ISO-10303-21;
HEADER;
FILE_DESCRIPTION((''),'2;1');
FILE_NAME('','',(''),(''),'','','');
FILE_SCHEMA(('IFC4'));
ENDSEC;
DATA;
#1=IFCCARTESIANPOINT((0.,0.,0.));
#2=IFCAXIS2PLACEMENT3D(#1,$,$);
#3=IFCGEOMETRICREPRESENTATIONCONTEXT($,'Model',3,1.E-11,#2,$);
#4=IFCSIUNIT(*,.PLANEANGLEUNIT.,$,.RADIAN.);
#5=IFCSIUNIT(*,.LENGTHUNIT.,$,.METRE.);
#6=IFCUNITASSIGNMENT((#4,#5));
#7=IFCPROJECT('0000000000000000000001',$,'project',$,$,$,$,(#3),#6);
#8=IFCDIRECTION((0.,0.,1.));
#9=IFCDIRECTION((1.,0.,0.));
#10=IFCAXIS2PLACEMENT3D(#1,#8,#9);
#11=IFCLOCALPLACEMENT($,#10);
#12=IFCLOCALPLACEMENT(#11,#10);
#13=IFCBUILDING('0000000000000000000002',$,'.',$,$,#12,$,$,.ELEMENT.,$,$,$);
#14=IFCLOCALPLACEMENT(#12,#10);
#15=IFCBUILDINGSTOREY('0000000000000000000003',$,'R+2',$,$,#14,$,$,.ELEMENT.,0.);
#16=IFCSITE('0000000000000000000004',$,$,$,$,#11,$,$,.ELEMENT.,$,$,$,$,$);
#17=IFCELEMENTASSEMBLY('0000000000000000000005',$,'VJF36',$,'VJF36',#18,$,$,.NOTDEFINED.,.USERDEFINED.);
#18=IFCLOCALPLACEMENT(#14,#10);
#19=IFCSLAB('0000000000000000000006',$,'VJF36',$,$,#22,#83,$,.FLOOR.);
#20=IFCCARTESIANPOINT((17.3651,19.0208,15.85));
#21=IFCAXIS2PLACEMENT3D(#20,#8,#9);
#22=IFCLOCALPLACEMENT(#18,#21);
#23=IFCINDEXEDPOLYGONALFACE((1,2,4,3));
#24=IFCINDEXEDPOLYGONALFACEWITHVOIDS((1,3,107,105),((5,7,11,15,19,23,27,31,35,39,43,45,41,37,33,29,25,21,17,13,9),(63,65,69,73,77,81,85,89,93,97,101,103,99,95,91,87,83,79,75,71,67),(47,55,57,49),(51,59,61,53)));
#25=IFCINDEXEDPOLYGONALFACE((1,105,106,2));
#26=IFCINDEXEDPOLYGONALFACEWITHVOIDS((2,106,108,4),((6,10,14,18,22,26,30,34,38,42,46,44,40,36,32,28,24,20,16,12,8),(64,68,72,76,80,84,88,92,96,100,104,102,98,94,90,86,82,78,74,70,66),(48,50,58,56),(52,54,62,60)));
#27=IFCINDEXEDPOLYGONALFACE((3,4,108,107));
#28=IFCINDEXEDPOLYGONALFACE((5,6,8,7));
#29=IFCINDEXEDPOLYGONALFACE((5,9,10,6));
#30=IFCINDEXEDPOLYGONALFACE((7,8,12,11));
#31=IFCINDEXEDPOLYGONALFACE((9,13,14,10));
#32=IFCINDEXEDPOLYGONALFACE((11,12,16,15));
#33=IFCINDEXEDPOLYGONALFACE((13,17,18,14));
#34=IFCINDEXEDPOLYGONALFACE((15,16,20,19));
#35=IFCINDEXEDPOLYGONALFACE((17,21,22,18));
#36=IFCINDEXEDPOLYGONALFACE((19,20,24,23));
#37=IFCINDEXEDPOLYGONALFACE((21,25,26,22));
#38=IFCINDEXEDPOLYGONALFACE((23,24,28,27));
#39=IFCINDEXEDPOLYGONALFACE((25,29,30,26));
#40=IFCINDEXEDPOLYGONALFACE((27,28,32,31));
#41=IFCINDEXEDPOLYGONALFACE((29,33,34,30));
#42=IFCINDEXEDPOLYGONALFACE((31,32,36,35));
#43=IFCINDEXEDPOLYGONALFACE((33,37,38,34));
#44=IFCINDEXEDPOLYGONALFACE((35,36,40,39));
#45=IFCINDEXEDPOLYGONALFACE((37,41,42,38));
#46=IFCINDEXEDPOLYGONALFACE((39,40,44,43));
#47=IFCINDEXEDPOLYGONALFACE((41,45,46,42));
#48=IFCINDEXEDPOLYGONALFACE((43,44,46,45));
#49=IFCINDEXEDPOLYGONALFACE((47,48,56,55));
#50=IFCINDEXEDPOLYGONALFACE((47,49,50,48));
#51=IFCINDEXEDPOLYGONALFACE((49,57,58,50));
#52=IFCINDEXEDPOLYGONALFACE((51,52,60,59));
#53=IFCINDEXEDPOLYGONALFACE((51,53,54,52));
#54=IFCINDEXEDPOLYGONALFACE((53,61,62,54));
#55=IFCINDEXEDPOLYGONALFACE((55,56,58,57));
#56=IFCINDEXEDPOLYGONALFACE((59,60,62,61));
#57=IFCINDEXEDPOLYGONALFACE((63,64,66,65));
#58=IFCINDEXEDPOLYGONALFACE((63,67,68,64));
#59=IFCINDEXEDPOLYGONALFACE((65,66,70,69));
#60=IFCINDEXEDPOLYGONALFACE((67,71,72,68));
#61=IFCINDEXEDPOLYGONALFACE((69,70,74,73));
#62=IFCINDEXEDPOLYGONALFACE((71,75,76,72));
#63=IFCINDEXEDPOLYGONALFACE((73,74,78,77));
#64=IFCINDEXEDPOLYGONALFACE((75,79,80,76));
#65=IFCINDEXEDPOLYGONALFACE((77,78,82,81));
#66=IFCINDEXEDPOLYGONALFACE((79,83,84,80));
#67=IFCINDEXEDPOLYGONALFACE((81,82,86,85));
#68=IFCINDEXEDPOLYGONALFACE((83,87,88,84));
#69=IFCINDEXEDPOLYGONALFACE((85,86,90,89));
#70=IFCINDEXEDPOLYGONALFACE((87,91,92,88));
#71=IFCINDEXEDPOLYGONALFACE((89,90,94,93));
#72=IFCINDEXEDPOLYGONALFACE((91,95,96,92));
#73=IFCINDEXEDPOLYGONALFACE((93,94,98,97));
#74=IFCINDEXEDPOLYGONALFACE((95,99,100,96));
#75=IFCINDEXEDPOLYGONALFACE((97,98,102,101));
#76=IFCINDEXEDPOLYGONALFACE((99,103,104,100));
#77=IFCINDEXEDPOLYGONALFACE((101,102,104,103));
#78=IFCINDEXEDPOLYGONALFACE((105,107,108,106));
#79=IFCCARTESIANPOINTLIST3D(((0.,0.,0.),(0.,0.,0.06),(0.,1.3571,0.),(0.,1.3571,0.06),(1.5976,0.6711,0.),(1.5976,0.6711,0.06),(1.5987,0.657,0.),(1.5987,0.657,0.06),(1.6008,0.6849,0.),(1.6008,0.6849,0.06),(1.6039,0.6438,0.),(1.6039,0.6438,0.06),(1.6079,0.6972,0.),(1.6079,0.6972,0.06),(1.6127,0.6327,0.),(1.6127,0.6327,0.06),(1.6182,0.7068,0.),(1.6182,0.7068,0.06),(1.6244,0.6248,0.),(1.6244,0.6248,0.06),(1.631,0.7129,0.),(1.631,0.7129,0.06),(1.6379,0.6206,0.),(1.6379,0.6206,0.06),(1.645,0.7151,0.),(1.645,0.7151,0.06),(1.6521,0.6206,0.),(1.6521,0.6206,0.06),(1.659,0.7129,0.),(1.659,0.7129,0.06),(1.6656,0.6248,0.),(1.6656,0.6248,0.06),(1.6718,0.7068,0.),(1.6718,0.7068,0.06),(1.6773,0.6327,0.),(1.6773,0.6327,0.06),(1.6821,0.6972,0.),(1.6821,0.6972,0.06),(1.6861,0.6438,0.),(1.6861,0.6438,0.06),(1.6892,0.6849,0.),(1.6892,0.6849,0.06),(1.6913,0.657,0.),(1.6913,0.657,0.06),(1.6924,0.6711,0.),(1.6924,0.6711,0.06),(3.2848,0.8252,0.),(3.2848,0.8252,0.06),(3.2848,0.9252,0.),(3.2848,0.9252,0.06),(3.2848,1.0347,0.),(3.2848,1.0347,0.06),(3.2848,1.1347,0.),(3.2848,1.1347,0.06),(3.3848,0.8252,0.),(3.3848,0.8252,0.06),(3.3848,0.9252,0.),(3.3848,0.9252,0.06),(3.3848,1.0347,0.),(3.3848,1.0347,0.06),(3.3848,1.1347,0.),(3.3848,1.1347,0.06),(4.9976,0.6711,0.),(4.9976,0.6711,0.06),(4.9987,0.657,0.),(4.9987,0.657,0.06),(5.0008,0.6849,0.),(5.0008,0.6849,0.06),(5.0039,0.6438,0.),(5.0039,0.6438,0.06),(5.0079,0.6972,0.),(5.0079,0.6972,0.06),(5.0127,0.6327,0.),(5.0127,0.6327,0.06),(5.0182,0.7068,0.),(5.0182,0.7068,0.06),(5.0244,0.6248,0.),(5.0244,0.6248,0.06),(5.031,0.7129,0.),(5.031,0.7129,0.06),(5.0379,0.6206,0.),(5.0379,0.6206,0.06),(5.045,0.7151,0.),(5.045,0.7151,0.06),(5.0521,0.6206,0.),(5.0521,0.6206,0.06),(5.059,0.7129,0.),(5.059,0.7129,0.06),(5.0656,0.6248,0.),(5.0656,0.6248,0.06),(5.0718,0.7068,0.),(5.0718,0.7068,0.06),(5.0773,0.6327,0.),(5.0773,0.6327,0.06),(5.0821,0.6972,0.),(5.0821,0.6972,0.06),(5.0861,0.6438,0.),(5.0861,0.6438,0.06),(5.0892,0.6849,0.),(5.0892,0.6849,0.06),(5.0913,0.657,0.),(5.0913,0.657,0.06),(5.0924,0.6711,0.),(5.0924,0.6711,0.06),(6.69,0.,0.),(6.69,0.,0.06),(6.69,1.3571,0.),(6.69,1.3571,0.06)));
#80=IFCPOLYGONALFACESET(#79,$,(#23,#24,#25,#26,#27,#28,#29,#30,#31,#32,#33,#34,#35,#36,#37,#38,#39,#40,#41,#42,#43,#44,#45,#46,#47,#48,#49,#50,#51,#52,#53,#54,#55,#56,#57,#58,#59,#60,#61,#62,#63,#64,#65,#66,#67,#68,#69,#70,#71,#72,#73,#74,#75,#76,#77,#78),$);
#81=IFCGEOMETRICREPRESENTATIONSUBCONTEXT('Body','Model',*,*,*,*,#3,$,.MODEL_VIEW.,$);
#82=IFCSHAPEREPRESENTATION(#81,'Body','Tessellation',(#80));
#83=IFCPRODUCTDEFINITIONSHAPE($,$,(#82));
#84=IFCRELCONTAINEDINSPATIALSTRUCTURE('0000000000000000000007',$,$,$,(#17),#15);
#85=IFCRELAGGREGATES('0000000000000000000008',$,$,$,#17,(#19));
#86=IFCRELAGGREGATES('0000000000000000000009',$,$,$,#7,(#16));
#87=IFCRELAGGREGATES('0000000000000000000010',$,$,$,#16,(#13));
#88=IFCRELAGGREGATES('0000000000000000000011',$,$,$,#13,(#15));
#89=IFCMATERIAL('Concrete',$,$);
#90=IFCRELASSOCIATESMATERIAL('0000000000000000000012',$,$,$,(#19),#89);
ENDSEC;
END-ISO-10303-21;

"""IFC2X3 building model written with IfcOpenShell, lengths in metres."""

from ifc_helpers import new_model, si_unit, frame, origin, origin_with_axes, origin_2d_with_axis, place, context, subcontext, project, spatial, polyline, circle, outline, extrude, material, element, aggregate, save


model = new_model("IFC2X3")

# Units and contexts
model_context = context("Model", 3, precision=1e-11, world=origin())
body_context = subcontext(model_context, "Body", "Model", "MODEL_VIEW")
ifc_project = project(units=[si_unit("PLANEANGLEUNIT", "RADIAN"), si_unit("LENGTHUNIT", "METRE")], contexts=[model_context])

# Site, building, storey
site_placement = place(None, origin_with_axes())
site = spatial("IfcSite", under=ifc_project, at=site_placement, CompositionType="ELEMENT")
building_placement = place(site_placement, origin_with_axes())
building = spatial("IfcBuilding", under=site, at=building_placement, Name=".", CompositionType="ELEMENT")
storey_placement = place(building_placement, origin_with_axes())
storey = spatial("IfcBuildingStorey", under=building, at=storey_placement, Name="R+2", CompositionType="ELEMENT", Elevation=0.0)

# Element assembly, slab, openings
assembly_1_placement = place(storey_placement, origin_with_axes())
assembly_1 = element("IfcElementAssembly", 1, at=assembly_1_placement, inside=storey, Name="VJF36", ObjectType="VJF36", AssemblyPlace="NOTDEFINED", PredefinedType="USERDEFINED")
ifc_material = material(Name="Concrete")
slab_1_placement = place(assembly_1_placement, frame((17.3651, 19.0208, 15.85), z_axis=(0.0, 0.0, 1.0), x_axis=(1.0, 0.0, 0.0)))
slab_1 = element("IfcSlab", 2, at=slab_1_placement, material=ifc_material, Name="VJF36", PredefinedType="FLOOR", context=body_context, shape_type="SweptSolid", body=[
    extrude(outline(polyline([(0.0, 0.0), (0.0, -6.69), (1.3571, -6.69), (1.3571, 0.0), (0.0, 0.0)])), frame((0.0, 0.0, 0.0), z_axis=(0.0, 0.0, 1.0), x_axis=(0.0, 1.0, 0.0)), (0.0, 0.0, 1.0), 0.06),
])
opening_1_placement = place(slab_1_placement, frame((5.045, 0.6676, 0.0), z_axis=(0.0, 0.0, 1.0), x_axis=(1.0, 0.0, 0.0)))
element("IfcOpeningElement", 3, at=opening_1_placement, cuts=slab_1, ObjectType="Opening", context=body_context, shape_type="SweptSolid", body=[
    extrude(circle(Radius=0.0475, at=origin_2d_with_axis()), frame((0.0, 0.0, 0.0), z_axis=(0.0, 0.0, 1.0), x_axis=(0.0, 1.0, 0.0)), (0.0, 0.0, 1.0), 0.06),
])
opening_2_placement = place(slab_1_placement, frame((1.645, 0.6676, 0.0), z_axis=(0.0, 0.0, 1.0), x_axis=(1.0, 0.0, 0.0)))
element("IfcOpeningElement", 4, at=opening_2_placement, cuts=slab_1, ObjectType="Opening", context=body_context, shape_type="SweptSolid", body=[
    extrude(circle(Radius=0.0475, at=origin_2d_with_axis()), frame((0.0, 0.0, 0.0), z_axis=(0.0, 0.0, 1.0), x_axis=(0.0, 1.0, 0.0)), (0.0, 0.0, 1.0), 0.06),
])
opening_3_placement = place(slab_1_placement, origin_with_axes())
element("IfcOpeningElement", 5, at=opening_3_placement, cuts=slab_1, ObjectType="Opening", context=body_context, shape_type="SweptSolid", body=[
    extrude(outline(polyline([(0.8252, -3.2848), (0.8252, -3.3848), (0.9252, -3.3848), (0.9252, -3.2848), (0.8252, -3.2848)])), frame((0.0, 0.0, 0.0), z_axis=(0.0, 0.0, 1.0), x_axis=(0.0, 1.0, 0.0)), (0.0, 0.0, 1.0), 0.06),
])
opening_4_placement = place(slab_1_placement, origin_with_axes())
element("IfcOpeningElement", 6, at=opening_4_placement, cuts=slab_1, ObjectType="Opening", context=body_context, shape_type="SweptSolid", body=[
    extrude(outline(polyline([(1.0347, -3.2848), (1.0347, -3.3848), (1.1347, -3.3848), (1.1347, -3.2848), (1.0347, -3.2848)])), frame((0.0, 0.0, 0.0), z_axis=(0.0, 0.0, 1.0), x_axis=(0.0, 1.0, 0.0)), (0.0, 0.0, 1.0), 0.06),
])

aggregate(assembly_1, [slab_1])

save(model, "model.ifc")
